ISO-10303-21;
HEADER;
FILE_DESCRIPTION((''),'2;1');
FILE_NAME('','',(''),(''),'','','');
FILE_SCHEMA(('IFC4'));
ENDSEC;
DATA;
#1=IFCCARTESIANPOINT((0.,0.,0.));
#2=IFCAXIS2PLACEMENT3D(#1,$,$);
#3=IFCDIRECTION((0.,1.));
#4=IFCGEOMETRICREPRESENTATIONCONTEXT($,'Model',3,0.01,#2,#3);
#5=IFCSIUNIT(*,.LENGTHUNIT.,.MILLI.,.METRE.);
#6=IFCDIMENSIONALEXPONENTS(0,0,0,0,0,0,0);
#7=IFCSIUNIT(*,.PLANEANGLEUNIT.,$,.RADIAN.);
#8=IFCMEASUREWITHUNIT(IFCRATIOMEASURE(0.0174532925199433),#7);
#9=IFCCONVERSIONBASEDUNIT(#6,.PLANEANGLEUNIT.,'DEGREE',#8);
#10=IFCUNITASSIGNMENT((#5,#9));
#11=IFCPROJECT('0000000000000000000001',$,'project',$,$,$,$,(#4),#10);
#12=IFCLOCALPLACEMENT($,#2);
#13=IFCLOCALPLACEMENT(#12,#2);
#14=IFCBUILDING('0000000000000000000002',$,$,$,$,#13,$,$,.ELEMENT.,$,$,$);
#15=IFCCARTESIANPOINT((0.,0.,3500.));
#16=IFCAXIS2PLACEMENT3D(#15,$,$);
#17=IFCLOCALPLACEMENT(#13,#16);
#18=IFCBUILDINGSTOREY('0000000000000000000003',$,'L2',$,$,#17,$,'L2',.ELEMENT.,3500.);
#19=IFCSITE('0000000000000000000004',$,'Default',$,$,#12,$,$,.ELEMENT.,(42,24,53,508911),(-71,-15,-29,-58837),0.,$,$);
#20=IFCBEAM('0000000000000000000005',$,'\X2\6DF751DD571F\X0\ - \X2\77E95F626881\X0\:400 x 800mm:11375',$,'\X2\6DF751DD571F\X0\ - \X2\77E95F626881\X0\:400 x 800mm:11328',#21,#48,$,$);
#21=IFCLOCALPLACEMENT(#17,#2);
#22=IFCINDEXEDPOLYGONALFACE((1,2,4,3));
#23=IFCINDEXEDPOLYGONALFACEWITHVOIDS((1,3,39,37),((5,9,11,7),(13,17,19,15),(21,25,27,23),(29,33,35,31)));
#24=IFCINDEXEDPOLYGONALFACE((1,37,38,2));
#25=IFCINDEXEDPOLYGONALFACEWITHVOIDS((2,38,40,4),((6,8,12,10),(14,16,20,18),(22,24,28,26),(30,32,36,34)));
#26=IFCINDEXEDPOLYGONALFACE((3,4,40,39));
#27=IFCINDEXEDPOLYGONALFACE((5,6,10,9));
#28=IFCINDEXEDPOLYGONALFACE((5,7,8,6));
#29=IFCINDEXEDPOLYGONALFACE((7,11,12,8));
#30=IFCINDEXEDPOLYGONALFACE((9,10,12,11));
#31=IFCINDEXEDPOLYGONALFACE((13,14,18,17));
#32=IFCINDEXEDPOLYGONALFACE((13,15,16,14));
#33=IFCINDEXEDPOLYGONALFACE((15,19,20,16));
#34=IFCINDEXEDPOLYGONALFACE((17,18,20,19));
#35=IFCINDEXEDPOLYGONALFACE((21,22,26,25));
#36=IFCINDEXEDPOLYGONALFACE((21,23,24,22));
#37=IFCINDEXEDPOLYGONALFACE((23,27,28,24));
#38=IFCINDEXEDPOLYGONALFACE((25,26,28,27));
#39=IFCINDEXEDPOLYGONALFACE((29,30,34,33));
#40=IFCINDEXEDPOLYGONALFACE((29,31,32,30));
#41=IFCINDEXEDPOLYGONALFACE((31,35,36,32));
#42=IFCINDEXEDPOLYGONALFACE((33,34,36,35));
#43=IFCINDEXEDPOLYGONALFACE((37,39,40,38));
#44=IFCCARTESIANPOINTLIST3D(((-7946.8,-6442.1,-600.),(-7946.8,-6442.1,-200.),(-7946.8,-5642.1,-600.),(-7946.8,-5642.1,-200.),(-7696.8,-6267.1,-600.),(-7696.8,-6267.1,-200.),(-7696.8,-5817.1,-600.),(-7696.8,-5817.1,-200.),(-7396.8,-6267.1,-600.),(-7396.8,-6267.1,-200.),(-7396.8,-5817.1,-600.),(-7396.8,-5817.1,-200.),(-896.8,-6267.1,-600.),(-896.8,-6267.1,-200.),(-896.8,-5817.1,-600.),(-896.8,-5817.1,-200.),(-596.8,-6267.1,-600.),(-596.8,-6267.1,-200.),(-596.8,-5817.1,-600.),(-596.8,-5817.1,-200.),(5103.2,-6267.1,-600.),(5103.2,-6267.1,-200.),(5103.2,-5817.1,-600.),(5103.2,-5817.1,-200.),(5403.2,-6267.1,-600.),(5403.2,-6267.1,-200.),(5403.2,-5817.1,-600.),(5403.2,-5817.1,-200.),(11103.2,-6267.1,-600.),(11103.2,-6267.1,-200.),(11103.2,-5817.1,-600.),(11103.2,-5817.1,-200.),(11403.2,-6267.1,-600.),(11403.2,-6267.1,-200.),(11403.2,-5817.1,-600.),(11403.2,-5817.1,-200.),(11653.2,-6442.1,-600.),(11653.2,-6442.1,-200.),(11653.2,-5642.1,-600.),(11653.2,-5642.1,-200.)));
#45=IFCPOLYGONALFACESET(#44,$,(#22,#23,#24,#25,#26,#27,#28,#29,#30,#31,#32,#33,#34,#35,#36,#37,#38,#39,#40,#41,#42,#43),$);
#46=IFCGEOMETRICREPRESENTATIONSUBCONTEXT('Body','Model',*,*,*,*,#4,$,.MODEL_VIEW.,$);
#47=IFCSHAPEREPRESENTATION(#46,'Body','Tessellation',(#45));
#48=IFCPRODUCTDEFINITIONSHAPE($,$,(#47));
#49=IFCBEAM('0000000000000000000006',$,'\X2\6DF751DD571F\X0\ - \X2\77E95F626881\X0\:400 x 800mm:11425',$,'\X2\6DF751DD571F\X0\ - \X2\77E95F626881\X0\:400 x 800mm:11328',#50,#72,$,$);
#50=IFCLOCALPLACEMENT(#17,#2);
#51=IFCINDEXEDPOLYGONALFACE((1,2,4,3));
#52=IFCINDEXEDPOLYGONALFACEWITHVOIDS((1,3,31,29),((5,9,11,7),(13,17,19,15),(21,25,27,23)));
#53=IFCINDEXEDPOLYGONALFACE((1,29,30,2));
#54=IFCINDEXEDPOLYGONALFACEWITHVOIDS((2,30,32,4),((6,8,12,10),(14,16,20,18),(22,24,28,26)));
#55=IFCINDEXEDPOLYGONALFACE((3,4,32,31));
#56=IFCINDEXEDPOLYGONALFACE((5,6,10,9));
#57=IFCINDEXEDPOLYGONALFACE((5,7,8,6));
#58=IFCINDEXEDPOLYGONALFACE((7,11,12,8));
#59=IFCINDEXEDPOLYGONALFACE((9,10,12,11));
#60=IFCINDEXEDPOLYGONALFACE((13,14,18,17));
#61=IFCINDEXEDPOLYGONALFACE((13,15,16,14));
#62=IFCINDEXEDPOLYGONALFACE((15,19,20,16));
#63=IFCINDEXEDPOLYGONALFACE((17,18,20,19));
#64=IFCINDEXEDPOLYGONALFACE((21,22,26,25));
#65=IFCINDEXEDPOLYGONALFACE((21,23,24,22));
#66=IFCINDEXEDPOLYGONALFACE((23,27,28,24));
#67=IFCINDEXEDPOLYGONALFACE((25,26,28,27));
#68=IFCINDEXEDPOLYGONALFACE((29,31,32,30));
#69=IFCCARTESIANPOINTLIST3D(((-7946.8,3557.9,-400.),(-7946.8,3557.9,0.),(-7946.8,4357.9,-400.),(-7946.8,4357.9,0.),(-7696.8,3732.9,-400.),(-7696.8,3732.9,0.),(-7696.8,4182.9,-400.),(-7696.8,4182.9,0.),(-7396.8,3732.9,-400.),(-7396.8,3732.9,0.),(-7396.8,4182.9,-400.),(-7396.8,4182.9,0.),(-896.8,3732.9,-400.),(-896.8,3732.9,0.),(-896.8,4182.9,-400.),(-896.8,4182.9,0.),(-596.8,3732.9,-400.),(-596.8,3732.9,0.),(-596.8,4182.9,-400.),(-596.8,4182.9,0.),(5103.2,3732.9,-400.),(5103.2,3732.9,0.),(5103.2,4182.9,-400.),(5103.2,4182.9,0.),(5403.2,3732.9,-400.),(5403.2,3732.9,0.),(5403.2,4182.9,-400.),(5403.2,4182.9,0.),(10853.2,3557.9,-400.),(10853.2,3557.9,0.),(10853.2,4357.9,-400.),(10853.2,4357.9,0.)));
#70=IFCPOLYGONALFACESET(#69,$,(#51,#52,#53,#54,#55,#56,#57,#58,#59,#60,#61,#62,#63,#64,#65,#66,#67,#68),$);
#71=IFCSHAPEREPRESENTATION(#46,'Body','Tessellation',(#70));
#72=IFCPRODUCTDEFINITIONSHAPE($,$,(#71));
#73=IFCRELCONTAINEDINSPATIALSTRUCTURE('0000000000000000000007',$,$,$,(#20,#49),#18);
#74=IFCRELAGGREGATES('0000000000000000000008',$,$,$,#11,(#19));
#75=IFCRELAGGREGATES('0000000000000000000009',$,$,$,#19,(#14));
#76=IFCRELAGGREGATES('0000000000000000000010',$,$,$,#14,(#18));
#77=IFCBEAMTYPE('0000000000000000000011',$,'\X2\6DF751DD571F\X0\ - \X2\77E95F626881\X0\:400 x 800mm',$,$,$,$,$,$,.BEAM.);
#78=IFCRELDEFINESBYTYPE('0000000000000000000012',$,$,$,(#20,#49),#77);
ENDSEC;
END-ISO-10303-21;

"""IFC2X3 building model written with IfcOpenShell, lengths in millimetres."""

from ifc_helpers import new_model, entity, si_unit, converted_unit, direction, frame, frame_2d, origin, origin_2d_with_axis, place, context, subcontext, project, spatial, rectangle, extrude, boolean, type_object, element, save


model = new_model("IFC2X3")

# Units and contexts
model_context = context("Model", 3, precision=0.01, world=origin(), true_north=direction((0.0, 1.0)))
body_context = subcontext(model_context, "Body", "Model", "MODEL_VIEW")
ifc_project = project(units=[si_unit("LENGTHUNIT", "METRE", prefix="MILLI"), converted_unit("PLANEANGLEUNIT", "DEGREE", entity("IfcRatioMeasure", 0.0174532925199433), si_unit("PLANEANGLEUNIT", "RADIAN"), dimensions=[0, 0, 0, 0, 0, 0, 0])], contexts=[model_context])

# Site, building, storey
site_placement = place(None, origin())
site = spatial("IfcSite", under=ifc_project, at=site_placement, Name="Default", CompositionType="ELEMENT", RefLatitude=(42, 24, 53, 508911), RefLongitude=(-71, -15, -29, -58837), RefElevation=0.0)
building_placement = place(site_placement, origin())
building = spatial("IfcBuilding", under=site, at=building_placement, CompositionType="ELEMENT")
storey_placement = place(building_placement, frame((0.0, 0.0, 3500.0)))
storey = spatial("IfcBuildingStorey", under=building, at=storey_placement, Name="L2", LongName="L2", CompositionType="ELEMENT", Elevation=3500.0)

# Beams
beam_type = type_object("IfcBeamType", Name="混凝土 - 矩形梁:400 x 800mm", PredefinedType="BEAM")
beam_1_placement = place(storey_placement, frame((-7546.8, -6042.1, 0.0)))
element("IfcBeam", 1, at=beam_1_placement, inside=storey, type_object=beam_type, Name="混凝土 - 矩形梁:400 x 800mm:11375", ObjectType="混凝土 - 矩形梁:400 x 800mm:11328", context=body_context, shape_type="CSG", body=[
    boolean("DIFFERENCE", boolean("DIFFERENCE", boolean("DIFFERENCE", boolean("DIFFERENCE", extrude(rectangle(XDim=400.0, YDim=800.0, at=frame_2d((0.0, 0.0), x_axis=(1.0, 0.0))), frame((-400.0, 0.0, -400.0), z_axis=(1.0, 0.0, 0.0), x_axis=(0.0, 0.0, -1.0)), (0.0, 0.0, 1.0), 19600.0), extrude(rectangle(XDim=300.0, YDim=450.0, at=frame_2d((0.0, 0.0), x_axis=(1.0, 0.0))), frame((12800.0, 0.0, -600.0), z_axis=(0.0, 0.0, 1.0), x_axis=(-1.0, 0.0, 0.0)), (0.0, 0.0, 1.0), 400.0)), extrude(rectangle(XDim=300.0, YDim=450.0, at=origin_2d_with_axis()), frame((6800.0, 0.0, -600.0), z_axis=(0.0, 0.0, 1.0), x_axis=(-1.0, 0.0, 0.0)), (0.0, 0.0, 1.0), 400.0)), extrude(rectangle(XDim=300.0, YDim=450.0, at=origin_2d_with_axis()), frame((18800.0, 0.0, -600.0), z_axis=(0.0, 0.0, 1.0), x_axis=(-1.0, 0.0, 0.0)), (0.0, 0.0, 1.0), 400.0)), extrude(rectangle(XDim=300.0, YDim=450.0, at=frame_2d((0.0, 0.0), x_axis=(1.0, 0.0))), frame((0.0, 0.0, -600.0), z_axis=(0.0, 0.0, 1.0), x_axis=(-1.0, 0.0, 0.0)), (0.0, 0.0, 1.0), 400.0)),
])
beam_2_placement = place(storey_placement, frame((11253.2, 3957.9, 0.0), z_axis=(0.0, 0.0, 1.0), x_axis=(-1.0, 0.0, 0.0)))
element("IfcBeam", 2, at=beam_2_placement, inside=storey, type_object=beam_type, Name="混凝土 - 矩形梁:400 x 800mm:11425", ObjectType="混凝土 - 矩形梁:400 x 800mm:11328", context=body_context, shape_type="CSG", body=[
    boolean("DIFFERENCE", boolean("DIFFERENCE", boolean("DIFFERENCE", extrude(rectangle(XDim=400.0, YDim=800.0, at=frame_2d((0.0, 0.0), x_axis=(1.0, 0.0))), frame((400.0, 0.0, -200.0), z_axis=(1.0, 0.0, 0.0), x_axis=(0.0, 0.0, -1.0)), (0.0, 0.0, 1.0), 18800.0), extrude(rectangle(XDim=300.0, YDim=450.0, at=frame_2d((0.0, 0.0), x_axis=(1.0, 0.0))), frame((12000.0, 0.0, -400.0)), (0.0, 0.0, 1.0), 400.0)), extrude(rectangle(XDim=300.0, YDim=450.0, at=frame_2d((0.0, 0.0), x_axis=(1.0, 0.0))), frame((6000.0, 0.0, -400.0)), (0.0, 0.0, 1.0), 400.0)), extrude(rectangle(XDim=300.0, YDim=450.0, at=frame_2d((0.0, 0.0), x_axis=(1.0, 0.0))), frame((18800.0, 0.0, -400.0)), (0.0, 0.0, 1.0), 400.0)),
])

save(model, "model.ifc")
